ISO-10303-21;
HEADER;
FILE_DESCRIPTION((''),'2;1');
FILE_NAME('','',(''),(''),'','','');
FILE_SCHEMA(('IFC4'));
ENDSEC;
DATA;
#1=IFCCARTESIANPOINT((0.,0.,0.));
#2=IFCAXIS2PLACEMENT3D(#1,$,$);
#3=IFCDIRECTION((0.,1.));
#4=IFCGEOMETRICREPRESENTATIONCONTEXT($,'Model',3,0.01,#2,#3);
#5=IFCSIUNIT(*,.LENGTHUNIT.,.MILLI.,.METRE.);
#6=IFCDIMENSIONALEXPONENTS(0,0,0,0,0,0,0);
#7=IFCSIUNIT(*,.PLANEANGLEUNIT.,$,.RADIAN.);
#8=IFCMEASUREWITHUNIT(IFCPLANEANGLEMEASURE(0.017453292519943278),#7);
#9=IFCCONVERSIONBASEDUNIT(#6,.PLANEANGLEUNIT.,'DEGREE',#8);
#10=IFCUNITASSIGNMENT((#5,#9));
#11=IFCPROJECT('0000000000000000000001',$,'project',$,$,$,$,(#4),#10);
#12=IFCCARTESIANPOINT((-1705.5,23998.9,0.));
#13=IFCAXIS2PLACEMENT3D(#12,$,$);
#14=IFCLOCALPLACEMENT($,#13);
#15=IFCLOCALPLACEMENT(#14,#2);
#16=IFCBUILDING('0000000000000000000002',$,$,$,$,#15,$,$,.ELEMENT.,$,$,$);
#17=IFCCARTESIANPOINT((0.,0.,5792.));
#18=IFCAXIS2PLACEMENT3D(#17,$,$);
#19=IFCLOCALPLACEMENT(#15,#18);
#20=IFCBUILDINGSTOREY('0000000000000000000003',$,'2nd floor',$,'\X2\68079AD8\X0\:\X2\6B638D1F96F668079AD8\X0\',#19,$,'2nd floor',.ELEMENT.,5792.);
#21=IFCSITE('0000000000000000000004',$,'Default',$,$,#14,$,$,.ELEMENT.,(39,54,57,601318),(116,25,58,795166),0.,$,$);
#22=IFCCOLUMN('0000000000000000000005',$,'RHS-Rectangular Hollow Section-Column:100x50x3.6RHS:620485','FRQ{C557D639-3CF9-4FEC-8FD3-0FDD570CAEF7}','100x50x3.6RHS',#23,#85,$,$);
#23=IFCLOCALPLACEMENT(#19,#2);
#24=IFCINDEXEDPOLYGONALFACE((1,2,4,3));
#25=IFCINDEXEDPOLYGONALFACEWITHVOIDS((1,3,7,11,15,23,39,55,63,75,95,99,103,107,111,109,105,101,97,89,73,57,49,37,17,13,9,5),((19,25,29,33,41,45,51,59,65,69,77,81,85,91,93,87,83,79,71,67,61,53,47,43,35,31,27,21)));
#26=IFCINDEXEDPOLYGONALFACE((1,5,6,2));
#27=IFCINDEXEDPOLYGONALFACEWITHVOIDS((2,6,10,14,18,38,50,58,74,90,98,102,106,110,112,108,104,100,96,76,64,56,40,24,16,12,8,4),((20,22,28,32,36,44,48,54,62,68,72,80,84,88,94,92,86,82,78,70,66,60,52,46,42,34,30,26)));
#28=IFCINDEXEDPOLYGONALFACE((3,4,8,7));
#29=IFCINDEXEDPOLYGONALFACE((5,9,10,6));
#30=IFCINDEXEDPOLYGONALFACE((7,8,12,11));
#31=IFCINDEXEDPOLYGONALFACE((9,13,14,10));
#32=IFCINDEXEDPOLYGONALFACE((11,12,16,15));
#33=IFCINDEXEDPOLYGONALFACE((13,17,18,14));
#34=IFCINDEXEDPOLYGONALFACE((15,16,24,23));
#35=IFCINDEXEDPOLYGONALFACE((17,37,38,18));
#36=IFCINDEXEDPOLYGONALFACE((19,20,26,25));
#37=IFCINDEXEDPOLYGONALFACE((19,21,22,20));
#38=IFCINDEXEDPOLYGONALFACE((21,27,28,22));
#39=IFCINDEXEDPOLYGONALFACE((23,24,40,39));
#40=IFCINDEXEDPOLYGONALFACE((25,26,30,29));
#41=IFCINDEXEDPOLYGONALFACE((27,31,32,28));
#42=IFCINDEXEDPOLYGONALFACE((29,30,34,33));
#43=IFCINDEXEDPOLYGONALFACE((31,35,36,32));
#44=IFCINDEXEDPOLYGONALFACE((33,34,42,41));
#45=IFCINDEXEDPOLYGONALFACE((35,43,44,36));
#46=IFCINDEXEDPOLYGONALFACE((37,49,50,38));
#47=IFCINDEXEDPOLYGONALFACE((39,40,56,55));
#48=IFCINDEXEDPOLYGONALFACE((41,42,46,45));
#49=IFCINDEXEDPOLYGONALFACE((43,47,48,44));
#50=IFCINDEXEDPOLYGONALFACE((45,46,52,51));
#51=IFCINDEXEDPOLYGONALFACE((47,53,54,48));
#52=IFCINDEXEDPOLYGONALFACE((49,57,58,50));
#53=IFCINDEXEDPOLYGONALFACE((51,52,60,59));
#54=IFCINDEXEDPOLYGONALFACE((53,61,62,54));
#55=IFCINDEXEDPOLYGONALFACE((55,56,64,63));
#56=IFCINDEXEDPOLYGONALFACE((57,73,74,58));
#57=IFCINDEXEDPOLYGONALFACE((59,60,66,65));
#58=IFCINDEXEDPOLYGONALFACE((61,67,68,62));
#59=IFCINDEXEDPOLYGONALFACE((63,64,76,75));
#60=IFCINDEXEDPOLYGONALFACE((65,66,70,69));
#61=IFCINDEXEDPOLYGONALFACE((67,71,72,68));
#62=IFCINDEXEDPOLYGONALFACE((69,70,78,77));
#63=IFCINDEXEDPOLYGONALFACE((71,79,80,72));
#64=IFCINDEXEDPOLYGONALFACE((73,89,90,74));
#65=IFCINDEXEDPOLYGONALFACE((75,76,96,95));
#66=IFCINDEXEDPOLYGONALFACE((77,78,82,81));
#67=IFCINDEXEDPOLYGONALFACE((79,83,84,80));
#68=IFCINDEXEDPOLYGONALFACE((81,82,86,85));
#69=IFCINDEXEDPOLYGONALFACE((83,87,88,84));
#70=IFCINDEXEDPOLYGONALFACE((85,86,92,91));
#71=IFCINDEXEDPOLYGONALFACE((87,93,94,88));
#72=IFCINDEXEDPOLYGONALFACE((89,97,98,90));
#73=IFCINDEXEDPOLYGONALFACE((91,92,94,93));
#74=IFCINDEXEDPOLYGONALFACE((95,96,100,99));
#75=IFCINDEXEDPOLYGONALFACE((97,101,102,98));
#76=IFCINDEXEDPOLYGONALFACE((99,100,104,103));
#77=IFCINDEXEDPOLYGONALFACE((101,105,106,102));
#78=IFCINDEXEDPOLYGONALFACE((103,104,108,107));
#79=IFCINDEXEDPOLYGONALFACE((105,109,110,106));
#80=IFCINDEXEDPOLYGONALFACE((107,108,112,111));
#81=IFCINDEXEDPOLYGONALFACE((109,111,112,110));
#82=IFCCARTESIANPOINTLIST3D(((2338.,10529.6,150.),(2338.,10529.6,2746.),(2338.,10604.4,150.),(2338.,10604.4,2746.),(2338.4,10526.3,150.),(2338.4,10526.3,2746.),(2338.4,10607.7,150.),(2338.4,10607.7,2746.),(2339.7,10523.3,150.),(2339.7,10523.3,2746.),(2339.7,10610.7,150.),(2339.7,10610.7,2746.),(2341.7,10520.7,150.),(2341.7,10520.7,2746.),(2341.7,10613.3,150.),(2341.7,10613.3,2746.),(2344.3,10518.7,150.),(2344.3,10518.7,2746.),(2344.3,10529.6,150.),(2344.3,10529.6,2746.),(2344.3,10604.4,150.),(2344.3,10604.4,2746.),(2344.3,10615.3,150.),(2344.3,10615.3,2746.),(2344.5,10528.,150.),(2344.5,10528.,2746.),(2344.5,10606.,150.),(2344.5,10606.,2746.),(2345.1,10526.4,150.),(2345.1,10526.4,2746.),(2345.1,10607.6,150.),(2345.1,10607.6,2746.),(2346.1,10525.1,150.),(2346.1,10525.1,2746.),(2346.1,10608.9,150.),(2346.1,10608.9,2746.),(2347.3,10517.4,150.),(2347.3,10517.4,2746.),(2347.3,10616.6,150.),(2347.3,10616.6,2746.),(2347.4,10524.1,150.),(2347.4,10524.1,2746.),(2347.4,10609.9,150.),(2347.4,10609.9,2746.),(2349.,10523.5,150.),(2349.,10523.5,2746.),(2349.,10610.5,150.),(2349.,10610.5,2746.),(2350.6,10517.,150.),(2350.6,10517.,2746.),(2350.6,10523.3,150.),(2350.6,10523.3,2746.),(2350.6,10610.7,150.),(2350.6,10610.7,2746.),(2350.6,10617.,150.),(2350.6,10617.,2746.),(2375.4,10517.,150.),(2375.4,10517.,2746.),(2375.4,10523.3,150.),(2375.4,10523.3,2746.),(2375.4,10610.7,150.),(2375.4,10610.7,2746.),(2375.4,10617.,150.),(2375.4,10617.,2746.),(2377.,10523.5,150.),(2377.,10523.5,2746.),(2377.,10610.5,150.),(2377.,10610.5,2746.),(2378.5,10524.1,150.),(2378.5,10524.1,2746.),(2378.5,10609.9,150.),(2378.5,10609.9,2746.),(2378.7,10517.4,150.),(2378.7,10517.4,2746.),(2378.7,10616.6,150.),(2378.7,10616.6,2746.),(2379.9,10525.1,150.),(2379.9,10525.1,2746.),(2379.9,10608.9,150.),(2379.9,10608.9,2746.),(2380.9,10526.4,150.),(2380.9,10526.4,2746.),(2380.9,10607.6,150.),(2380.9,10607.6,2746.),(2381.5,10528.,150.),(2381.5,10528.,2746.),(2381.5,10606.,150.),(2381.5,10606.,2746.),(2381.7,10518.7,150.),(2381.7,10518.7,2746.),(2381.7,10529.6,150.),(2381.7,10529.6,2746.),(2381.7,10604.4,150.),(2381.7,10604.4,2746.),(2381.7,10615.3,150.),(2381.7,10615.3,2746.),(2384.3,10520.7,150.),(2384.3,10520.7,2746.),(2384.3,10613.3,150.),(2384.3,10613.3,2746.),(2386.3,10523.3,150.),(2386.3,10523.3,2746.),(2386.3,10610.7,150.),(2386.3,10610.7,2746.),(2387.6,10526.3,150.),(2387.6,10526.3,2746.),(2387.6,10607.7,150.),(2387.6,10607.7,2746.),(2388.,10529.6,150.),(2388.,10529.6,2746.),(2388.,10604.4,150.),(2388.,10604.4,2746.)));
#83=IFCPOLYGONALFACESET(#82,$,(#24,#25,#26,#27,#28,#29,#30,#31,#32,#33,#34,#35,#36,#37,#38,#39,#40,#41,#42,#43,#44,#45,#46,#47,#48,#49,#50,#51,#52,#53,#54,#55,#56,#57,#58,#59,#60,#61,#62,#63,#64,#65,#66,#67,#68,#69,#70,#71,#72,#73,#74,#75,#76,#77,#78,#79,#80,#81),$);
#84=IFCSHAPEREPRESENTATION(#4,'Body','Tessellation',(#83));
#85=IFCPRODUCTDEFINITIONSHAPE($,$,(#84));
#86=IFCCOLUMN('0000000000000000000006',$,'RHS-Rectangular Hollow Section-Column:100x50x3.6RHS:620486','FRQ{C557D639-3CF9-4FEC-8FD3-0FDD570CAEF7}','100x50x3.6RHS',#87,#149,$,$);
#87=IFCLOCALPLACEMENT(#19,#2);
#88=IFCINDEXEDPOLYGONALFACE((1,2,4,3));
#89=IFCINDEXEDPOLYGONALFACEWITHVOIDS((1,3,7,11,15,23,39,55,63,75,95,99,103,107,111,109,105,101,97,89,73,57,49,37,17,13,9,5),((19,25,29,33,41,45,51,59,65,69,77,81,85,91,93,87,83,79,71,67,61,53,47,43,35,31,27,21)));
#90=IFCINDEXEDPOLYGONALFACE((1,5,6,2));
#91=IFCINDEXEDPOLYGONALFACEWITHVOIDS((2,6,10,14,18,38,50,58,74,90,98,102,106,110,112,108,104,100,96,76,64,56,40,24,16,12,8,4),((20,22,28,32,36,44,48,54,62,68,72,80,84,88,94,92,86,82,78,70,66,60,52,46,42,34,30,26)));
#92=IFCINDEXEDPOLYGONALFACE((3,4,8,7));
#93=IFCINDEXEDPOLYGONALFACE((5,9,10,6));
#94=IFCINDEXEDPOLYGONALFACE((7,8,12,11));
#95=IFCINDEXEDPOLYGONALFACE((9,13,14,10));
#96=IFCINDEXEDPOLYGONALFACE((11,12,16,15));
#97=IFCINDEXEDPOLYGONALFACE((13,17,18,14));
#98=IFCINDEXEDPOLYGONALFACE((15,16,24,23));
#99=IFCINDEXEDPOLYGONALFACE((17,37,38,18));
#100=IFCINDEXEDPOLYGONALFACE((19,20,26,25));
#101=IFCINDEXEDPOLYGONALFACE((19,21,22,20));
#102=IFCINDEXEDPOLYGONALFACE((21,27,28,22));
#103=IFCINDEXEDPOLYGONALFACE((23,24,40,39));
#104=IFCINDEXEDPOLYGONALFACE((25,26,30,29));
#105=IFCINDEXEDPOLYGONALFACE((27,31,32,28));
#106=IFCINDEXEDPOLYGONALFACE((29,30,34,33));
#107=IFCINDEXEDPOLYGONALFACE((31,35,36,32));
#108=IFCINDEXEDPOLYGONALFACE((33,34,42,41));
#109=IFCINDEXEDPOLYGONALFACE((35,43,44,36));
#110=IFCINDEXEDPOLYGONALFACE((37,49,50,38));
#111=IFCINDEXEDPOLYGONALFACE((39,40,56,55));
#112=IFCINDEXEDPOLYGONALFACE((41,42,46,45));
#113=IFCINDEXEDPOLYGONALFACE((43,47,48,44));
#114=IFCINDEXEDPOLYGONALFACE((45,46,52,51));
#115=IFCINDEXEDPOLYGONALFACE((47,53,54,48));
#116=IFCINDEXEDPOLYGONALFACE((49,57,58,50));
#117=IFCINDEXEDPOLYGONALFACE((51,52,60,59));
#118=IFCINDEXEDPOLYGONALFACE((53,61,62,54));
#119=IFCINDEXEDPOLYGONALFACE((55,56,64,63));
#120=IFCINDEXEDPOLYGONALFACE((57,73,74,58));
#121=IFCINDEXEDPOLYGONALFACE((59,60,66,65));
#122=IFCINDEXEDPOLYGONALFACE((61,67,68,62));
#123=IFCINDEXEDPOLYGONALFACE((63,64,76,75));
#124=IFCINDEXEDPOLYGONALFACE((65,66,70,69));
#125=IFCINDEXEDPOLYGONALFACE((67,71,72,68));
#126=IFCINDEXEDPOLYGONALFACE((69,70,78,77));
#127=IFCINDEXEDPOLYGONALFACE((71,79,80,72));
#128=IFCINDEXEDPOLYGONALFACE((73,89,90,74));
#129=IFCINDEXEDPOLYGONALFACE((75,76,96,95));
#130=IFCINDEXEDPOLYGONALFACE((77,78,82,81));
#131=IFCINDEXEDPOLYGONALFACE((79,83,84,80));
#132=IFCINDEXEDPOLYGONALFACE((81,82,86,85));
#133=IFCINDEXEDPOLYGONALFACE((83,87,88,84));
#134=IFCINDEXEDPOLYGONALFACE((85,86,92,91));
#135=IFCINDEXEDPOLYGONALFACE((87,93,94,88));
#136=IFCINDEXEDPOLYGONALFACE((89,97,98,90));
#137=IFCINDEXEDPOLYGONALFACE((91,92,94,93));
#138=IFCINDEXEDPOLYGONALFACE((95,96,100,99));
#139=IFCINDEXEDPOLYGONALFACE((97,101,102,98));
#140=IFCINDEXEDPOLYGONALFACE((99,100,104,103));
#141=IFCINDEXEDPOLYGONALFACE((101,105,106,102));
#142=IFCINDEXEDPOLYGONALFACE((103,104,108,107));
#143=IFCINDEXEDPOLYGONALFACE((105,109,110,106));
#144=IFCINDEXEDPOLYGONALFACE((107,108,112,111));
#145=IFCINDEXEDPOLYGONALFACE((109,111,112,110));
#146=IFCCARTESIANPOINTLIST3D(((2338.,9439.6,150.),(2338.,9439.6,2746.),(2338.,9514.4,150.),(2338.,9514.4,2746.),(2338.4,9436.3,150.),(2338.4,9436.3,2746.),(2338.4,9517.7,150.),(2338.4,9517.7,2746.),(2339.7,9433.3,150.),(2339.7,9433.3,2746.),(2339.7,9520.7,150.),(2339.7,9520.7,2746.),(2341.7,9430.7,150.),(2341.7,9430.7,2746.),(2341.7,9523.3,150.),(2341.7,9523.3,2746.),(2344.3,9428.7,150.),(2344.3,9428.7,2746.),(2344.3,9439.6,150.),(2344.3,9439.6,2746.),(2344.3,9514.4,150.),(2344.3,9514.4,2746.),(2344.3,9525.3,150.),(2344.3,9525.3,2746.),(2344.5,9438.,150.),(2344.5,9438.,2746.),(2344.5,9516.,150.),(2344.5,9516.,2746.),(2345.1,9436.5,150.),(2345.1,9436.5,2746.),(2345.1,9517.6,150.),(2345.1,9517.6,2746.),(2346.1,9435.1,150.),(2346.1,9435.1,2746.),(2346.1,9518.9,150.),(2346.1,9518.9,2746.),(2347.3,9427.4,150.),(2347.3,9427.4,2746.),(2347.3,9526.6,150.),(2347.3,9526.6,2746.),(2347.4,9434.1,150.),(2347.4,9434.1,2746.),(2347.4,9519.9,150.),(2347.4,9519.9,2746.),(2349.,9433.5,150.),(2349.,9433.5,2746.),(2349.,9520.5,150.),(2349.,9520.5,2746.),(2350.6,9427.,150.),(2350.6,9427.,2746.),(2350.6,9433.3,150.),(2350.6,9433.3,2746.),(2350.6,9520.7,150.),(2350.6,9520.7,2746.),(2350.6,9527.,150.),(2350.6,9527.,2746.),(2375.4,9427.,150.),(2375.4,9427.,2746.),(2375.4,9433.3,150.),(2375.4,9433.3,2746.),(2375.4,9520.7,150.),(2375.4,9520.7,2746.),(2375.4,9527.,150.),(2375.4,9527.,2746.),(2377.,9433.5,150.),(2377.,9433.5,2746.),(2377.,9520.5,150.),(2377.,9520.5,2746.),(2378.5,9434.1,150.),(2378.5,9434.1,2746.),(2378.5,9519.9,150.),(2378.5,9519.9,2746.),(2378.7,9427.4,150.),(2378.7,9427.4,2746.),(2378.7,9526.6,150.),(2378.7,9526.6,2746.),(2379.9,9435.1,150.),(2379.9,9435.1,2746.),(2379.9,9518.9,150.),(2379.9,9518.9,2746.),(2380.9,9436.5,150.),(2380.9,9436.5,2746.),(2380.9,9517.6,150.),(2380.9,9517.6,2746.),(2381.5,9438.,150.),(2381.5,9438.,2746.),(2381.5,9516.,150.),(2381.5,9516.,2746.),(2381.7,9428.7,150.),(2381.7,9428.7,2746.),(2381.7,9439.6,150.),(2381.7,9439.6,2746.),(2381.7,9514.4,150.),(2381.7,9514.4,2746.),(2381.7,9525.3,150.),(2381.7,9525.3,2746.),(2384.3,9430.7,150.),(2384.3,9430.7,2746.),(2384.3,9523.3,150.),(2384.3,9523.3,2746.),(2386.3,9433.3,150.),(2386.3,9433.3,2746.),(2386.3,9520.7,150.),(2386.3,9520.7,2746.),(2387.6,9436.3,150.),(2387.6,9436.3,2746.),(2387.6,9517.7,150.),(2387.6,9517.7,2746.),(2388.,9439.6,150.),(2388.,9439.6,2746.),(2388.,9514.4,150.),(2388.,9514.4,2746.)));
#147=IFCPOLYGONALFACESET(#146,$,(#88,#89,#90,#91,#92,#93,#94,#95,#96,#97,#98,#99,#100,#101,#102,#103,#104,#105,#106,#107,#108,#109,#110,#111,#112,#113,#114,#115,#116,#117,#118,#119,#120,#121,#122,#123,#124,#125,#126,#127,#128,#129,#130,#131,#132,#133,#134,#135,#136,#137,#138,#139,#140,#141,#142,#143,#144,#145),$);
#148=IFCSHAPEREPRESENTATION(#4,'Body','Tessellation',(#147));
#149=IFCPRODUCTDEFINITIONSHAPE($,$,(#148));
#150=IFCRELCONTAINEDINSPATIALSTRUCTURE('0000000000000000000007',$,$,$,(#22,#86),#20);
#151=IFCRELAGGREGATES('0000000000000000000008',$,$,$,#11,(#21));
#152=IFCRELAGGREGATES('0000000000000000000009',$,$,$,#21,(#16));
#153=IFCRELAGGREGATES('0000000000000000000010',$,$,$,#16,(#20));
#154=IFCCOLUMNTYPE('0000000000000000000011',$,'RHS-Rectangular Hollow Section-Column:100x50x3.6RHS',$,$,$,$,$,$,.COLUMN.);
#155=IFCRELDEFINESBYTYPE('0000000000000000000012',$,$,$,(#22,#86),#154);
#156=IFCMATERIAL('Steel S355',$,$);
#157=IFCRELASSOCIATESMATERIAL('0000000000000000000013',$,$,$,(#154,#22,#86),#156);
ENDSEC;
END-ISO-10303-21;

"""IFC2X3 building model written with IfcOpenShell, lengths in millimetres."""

from ifc_helpers import new_model, entity, si_unit, converted_unit, direction, frame, origin, origin_2d, place, context, project, spatial, hollow_rectangle, extrude, clip, halfspace, material, type_object, element, save


model = new_model("IFC2X3")

# Units and contexts
model_context = context("Model", 3, precision=0.01, world=origin(), true_north=direction((0.0, 1.0)))
ifc_project = project(units=[si_unit("LENGTHUNIT", "METRE", prefix="MILLI"), converted_unit("PLANEANGLEUNIT", "DEGREE", entity("IfcPlaneAngleMeasure", 0.017453292519943278), si_unit("PLANEANGLEUNIT", "RADIAN"), dimensions=[0, 0, 0, 0, 0, 0, 0])], contexts=[model_context])

# Site, building, storey
site_placement = place(None, frame((-1705.5, 23998.9, 0.0)))
site = spatial("IfcSite", under=ifc_project, at=site_placement, Name="Default", CompositionType="ELEMENT", RefLatitude=(39, 54, 57, 601318), RefLongitude=(116, 25, 58, 795166), RefElevation=0.0)
building_placement = place(site_placement, origin())
building = spatial("IfcBuilding", under=site, at=building_placement, CompositionType="ELEMENT")
storey_placement = place(building_placement, frame((0.0, 0.0, 5792.0)))
storey = spatial("IfcBuildingStorey", under=building, at=storey_placement, Name="2nd floor", ObjectType="标高:正负零标高", LongName="2nd floor", CompositionType="ELEMENT", Elevation=5792.0)

# Shared definitions
ifc_material_1 = material(Name="Steel S355")

# Columns
column_type_1 = type_object("IfcColumnType", Name="RHS-Rectangular Hollow Section-Column:100x50x3.6RHS", PredefinedType="COLUMN", material=ifc_material_1)
column_1_placement = place(storey_placement, frame((2363.0, 10567.0, 2746.0), z_axis=(0.0, 0.0, 1.0), x_axis=(-1.0, 0.0, 0.0)))
element("IfcColumn", 1, at=column_1_placement, inside=storey, type_object=column_type_1, material=ifc_material_1, Name="RHS-Rectangular Hollow Section-Column:100x50x3.6RHS:620485", Description="FRQ{C557D639-3CF9-4FEC-8FD3-0FDD570CAEF7}", ObjectType="100x50x3.6RHS", context=model_context, shape_type="Clipping", body=[
    clip(extrude(hollow_rectangle(XDim=50.0, YDim=100.0, WallThickness=6.3, InnerFilletRadius=6.3, OuterFilletRadius=12.6, at=origin_2d()), origin(), (0.0, 0.0, -1.0), 2651.9), halfspace(frame((2363.0, 10567.0, -2596.0), z_axis=(0.0, 0.0, 1.0), x_axis=(-1.0, 0.0, 0.0)), True)),
])
column_2_placement = place(storey_placement, frame((2363.0, 9477.0, 2746.0), z_axis=(0.0, 0.0, 1.0), x_axis=(-1.0, 0.0, 0.0)))
element("IfcColumn", 2, at=column_2_placement, inside=storey, type_object=column_type_1, material=ifc_material_1, Name="RHS-Rectangular Hollow Section-Column:100x50x3.6RHS:620486", Description="FRQ{C557D639-3CF9-4FEC-8FD3-0FDD570CAEF7}", ObjectType="100x50x3.6RHS", context=model_context, shape_type="Clipping", body=[
    clip(extrude(hollow_rectangle(XDim=50.0, YDim=100.0, WallThickness=6.3, InnerFilletRadius=6.3, OuterFilletRadius=12.6, at=origin_2d()), origin(), (0.0, 0.0, -1.0), 2651.9), halfspace(frame((2363.0, 9477.0, -2596.0), z_axis=(0.0, 0.0, 1.0), x_axis=(-1.0, 0.0, 0.0)), True)),
])

save(model, "model.ifc")
